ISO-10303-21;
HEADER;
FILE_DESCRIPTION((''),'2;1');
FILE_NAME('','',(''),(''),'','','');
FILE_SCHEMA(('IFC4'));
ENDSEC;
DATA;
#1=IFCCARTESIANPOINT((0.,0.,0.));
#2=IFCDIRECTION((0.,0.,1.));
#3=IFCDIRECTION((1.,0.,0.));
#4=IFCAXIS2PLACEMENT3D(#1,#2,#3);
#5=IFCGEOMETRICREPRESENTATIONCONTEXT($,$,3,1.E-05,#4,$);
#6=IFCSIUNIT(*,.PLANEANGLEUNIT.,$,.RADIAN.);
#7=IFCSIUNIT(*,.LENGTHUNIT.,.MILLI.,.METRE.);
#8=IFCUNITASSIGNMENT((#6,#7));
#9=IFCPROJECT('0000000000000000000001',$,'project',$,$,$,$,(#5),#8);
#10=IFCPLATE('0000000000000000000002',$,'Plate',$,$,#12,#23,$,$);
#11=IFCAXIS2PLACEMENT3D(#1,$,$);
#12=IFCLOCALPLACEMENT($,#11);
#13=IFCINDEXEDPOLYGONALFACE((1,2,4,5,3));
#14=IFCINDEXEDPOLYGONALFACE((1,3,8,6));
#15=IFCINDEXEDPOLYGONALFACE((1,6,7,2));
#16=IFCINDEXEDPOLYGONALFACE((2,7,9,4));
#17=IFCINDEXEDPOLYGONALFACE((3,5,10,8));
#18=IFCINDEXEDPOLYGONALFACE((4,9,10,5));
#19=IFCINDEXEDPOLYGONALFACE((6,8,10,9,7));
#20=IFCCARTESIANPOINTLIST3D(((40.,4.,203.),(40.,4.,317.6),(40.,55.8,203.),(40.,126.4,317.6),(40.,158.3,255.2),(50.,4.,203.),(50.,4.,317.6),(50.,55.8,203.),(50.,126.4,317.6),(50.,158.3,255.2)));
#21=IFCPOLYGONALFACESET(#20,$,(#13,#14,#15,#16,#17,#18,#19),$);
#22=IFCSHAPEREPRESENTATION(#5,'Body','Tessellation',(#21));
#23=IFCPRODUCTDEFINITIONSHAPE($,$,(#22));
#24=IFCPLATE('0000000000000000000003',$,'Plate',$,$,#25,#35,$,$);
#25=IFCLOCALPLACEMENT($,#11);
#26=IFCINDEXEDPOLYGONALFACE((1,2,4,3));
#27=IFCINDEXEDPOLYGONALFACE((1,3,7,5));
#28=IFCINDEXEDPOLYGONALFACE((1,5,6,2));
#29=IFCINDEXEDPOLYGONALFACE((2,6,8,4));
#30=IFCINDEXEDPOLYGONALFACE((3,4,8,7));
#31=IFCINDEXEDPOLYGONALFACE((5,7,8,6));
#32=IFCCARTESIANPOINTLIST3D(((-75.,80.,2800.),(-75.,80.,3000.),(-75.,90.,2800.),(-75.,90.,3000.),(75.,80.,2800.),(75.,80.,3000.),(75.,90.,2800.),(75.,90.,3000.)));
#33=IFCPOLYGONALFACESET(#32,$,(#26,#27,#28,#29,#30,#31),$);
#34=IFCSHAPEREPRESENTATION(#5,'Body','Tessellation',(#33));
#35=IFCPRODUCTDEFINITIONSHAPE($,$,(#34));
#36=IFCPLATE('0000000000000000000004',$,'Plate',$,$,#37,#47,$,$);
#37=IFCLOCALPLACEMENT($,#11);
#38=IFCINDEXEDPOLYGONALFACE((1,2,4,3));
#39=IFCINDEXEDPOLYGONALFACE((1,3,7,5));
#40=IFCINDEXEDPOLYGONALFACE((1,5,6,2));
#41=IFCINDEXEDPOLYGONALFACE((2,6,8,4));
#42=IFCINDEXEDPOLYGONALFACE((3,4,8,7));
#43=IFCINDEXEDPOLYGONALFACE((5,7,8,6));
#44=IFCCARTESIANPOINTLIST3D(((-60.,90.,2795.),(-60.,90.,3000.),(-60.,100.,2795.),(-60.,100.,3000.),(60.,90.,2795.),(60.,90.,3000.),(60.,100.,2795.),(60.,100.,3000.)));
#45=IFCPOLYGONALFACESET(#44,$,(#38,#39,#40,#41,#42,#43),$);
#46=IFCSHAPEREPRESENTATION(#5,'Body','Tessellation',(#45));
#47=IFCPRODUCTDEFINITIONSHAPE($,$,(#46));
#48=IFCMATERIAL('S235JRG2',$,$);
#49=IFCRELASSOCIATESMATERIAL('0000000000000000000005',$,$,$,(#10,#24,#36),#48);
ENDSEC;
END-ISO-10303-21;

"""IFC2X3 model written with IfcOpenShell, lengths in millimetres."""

from ifc_helpers import new_model, si_unit, frame, origin_with_axes, place, context, project, polyline, outline, extrude, material, element, save


model = new_model("IFC2X3")

# Units and contexts
context_of_model = context(None, 3, precision=1e-05, world=origin_with_axes())
ifc_project = project(units=[si_unit("PLANEANGLEUNIT", "RADIAN"), si_unit("LENGTHUNIT", "METRE", prefix="MILLI")], contexts=[context_of_model])

# Shared definitions
ifc_material = material(Name="S235JRG2")

# Plates
placement_1 = place(None, origin_with_axes())
plate_1_placement = place(placement_1, frame((50.0, 55.8, 203.0), z_axis=(0.0, 0.0, 1.0), x_axis=(-1.0, 0.0, 0.0)))
element("IfcPlate", 1, at=plate_1_placement, material=ifc_material, Name="Plate", context=context_of_model, shape_type="SweptSolid", body=[
    extrude(outline(polyline([(0.0, 0.0), (51.8, 0.0), (51.8, 114.6), (-70.6, 114.6), (-102.4, 52.3), (0.0, 0.0)])), frame((0.0, 0.0, 0.0), z_axis=(1.0, 0.0, 0.0), x_axis=(0.0, 1.0, 0.0)), (0.0, 0.0, 1.0), 10.0),
])
placement_2 = place(None, origin_with_axes())
plate_2_placement = place(placement_2, frame((-75.0, 80.0, 3000.0), z_axis=(0.0, 0.0, -1.0), x_axis=(0.0, 1.0, 0.0)))
element("IfcPlate", 2, at=plate_2_placement, material=ifc_material, Name="Plate", context=context_of_model, shape_type="SweptSolid", body=[
    extrude(outline(polyline([(0.0, 0.0), (150.0, 0.0), (150.0, 200.0), (0.0, 200.0), (0.0, 0.0)])), frame((0.0, 0.0, 0.0), z_axis=(1.0, 0.0, 0.0), x_axis=(0.0, 1.0, 0.0)), (0.0, 0.0, 1.0), 10.0),
])
placement_3 = place(None, origin_with_axes())
plate_3_placement = place(placement_3, frame((60.0, 100.0, 3000.0), z_axis=(0.0, 0.0, -1.0), x_axis=(0.0, -1.0, 0.0)))
element("IfcPlate", 3, at=plate_3_placement, material=ifc_material, Name="Plate", context=context_of_model, shape_type="SweptSolid", body=[
    extrude(outline(polyline([(0.0, 0.0), (120.0, 0.0), (120.0, 205.0), (0.0, 205.0), (0.0, 0.0)])), frame((0.0, 0.0, 0.0), z_axis=(1.0, 0.0, 0.0), x_axis=(0.0, 1.0, 0.0)), (0.0, 0.0, 1.0), 10.0),
])

save(model, "model.ifc")
